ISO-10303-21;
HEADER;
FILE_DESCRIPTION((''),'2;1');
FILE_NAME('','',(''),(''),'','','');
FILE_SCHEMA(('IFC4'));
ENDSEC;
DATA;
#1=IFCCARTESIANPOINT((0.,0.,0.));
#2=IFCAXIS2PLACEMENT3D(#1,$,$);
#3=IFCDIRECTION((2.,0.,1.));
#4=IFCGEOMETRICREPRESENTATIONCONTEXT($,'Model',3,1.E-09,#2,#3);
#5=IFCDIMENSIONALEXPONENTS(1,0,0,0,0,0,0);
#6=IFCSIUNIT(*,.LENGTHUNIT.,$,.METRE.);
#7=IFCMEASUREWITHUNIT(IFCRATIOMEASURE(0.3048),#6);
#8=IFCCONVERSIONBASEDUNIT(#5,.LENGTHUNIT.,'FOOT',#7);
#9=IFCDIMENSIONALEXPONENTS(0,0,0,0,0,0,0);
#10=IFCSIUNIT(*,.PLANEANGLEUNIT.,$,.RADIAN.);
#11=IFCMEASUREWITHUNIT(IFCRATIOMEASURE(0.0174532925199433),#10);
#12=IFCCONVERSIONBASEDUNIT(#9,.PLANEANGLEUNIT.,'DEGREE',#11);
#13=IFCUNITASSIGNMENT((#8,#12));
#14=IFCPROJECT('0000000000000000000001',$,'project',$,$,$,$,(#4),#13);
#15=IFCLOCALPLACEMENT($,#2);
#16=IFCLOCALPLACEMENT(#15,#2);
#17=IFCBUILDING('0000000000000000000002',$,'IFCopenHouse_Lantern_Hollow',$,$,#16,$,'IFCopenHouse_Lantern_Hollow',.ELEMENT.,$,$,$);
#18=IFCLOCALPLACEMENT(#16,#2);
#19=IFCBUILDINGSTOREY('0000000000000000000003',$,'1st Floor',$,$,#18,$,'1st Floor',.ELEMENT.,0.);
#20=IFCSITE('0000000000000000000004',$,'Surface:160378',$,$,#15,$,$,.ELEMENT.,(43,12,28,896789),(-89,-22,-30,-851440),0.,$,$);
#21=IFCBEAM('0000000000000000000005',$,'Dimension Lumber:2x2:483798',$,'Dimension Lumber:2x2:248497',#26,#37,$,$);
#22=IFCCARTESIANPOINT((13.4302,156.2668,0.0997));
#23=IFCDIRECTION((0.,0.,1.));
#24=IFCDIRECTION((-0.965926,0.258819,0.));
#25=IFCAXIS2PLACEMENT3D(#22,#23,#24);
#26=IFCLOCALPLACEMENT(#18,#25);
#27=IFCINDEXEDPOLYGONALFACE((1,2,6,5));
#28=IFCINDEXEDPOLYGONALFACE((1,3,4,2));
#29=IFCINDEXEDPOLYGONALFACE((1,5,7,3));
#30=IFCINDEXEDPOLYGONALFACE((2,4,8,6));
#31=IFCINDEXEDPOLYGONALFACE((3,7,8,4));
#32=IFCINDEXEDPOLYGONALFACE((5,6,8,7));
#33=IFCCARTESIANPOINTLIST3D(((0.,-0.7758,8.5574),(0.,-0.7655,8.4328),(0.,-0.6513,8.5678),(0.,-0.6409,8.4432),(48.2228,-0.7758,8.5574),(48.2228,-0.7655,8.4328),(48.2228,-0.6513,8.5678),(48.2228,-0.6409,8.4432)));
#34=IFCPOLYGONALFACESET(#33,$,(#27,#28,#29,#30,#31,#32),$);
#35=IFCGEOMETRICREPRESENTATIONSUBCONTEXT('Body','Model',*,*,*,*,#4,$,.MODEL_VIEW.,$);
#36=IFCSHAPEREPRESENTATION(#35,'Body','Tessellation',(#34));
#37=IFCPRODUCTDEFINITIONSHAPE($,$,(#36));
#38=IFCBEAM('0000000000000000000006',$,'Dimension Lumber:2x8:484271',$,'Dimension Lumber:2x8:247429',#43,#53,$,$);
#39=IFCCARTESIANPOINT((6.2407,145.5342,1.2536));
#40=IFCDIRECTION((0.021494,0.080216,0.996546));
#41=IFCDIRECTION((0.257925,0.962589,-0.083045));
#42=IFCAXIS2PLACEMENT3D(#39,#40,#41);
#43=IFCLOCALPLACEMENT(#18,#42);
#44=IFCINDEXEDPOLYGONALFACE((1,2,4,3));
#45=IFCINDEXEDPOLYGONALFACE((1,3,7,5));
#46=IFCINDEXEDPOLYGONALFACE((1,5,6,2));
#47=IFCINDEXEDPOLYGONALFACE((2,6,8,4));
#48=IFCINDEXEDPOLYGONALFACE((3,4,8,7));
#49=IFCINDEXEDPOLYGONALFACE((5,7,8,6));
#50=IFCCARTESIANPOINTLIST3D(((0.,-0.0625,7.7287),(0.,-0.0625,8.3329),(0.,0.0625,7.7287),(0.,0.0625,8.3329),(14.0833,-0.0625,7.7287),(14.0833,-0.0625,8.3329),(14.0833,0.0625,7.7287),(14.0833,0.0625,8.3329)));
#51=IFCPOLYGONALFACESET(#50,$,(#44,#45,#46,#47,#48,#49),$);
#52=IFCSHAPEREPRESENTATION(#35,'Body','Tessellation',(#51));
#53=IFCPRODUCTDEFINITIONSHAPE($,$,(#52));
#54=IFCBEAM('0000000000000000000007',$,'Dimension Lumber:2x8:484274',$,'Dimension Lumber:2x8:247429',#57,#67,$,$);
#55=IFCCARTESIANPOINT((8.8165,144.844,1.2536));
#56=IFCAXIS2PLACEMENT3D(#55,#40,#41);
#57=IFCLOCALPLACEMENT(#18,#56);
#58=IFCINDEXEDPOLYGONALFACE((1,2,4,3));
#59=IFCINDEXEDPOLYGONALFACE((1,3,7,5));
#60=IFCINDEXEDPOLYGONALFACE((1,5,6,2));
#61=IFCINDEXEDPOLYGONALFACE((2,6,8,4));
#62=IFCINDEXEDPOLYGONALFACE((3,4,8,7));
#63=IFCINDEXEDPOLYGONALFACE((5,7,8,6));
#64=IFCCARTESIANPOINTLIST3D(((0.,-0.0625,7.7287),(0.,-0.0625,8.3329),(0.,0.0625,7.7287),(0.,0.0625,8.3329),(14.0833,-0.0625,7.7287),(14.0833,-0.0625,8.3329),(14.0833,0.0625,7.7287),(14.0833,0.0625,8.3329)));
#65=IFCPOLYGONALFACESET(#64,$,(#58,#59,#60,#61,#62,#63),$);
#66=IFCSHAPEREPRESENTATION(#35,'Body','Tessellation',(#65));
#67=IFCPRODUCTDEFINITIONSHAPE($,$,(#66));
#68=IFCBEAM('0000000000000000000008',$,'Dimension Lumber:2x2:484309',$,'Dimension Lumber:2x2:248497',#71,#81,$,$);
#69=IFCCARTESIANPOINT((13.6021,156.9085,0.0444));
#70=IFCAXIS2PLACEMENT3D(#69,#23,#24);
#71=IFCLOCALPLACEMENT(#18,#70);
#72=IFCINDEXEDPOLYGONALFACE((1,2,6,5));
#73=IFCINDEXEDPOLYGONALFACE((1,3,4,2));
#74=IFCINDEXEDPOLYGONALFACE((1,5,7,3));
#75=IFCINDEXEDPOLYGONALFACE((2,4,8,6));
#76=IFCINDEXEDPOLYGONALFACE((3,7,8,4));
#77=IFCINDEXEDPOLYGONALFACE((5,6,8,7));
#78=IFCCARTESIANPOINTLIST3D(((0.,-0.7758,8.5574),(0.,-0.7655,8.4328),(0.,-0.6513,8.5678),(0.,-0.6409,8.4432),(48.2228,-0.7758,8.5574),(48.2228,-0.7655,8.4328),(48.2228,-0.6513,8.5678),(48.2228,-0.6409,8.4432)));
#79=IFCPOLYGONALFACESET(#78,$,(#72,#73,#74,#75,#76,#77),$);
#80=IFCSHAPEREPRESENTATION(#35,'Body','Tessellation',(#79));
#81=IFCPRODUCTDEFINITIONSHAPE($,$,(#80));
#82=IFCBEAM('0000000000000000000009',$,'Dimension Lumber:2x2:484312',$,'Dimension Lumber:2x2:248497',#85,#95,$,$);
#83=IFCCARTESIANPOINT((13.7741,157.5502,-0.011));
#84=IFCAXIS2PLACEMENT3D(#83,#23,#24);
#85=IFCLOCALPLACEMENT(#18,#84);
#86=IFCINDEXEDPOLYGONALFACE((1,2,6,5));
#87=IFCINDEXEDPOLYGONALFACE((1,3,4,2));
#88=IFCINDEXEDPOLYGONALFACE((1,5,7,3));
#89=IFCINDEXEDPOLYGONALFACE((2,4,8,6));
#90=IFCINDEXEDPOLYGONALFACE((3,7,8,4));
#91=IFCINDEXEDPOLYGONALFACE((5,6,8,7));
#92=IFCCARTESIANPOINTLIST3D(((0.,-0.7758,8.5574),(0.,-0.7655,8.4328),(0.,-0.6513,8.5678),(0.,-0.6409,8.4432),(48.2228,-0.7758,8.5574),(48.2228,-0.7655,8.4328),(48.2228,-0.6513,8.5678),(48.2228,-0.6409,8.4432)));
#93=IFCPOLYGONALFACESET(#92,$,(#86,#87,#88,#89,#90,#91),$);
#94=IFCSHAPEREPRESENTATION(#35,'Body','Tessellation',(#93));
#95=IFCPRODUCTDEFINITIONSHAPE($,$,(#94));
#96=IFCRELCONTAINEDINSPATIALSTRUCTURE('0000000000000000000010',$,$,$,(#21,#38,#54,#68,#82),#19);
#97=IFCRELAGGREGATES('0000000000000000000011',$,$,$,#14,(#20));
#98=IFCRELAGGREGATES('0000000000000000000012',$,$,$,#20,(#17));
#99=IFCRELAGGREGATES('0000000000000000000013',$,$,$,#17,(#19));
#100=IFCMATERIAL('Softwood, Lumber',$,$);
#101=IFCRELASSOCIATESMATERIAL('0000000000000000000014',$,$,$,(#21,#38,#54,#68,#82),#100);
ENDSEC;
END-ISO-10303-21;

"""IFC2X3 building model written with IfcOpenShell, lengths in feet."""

from ifc_helpers import new_model, entity, si_unit, converted_unit, direction, frame, frame_2d, origin, place, context, subcontext, project, spatial, rectangle, extrude, material, element, save


model = new_model("IFC2X3")

# Units and contexts
model_context = context("Model", 3, precision=1e-09, world=origin(), true_north=direction((2.0, 0.0, 1.0)))
body_context = subcontext(model_context, "Body", "Model", "MODEL_VIEW")
ifc_project = project(units=[converted_unit("LENGTHUNIT", "FOOT", entity("IfcRatioMeasure", 0.3048), si_unit("LENGTHUNIT", "METRE"), dimensions=[1, 0, 0, 0, 0, 0, 0]), converted_unit("PLANEANGLEUNIT", "DEGREE", entity("IfcRatioMeasure", 0.0174532925199433), si_unit("PLANEANGLEUNIT", "RADIAN"), dimensions=[0, 0, 0, 0, 0, 0, 0])], contexts=[model_context])

# Site, building, storey
site_placement = place(None, origin())
site = spatial("IfcSite", under=ifc_project, at=site_placement, Name="Surface:160378", CompositionType="ELEMENT", RefLatitude=(43, 12, 28, 896789), RefLongitude=(-89, -22, -30, -851440), RefElevation=0.0)
building_placement = place(site_placement, origin())
building = spatial("IfcBuilding", under=site, at=building_placement, Name="IFCopenHouse_Lantern_Hollow", LongName="IFCopenHouse_Lantern_Hollow", CompositionType="ELEMENT")
storey_placement = place(building_placement, origin())
storey = spatial("IfcBuildingStorey", under=building, at=storey_placement, Name="1st Floor", LongName="1st Floor", CompositionType="ELEMENT", Elevation=0.0)

# Beams
ifc_material = material(Name="Softwood, Lumber")
beam_1_placement = place(storey_placement, frame((13.4302, 156.2668, 0.0997), z_axis=(0.0, 0.0, 1.0), x_axis=(-0.965926, 0.258819, 0.0)))
element("IfcBeam", 1, at=beam_1_placement, inside=storey, material=ifc_material, Name="Dimension Lumber:2x2:483798", ObjectType="Dimension Lumber:2x2:248497", context=body_context, shape_type="SweptSolid", body=[
    extrude(rectangle(XDim=0.125, YDim=0.125, at=frame_2d((0.0, 0.0), x_axis=(0.0, 1.0))), frame((0.0, -0.7084, 8.5003), z_axis=(1.0, 0.0, 0.0), x_axis=(0.0, -0.996546, -0.083045)), (0.0, 0.0, 1.0), 48.2228),
])
beam_2_placement = place(storey_placement, frame((6.2407, 145.5342, 1.2536), z_axis=(0.021494, 0.080216, 0.996546), x_axis=(0.257925, 0.962589, -0.083045)))
element("IfcBeam", 2, at=beam_2_placement, inside=storey, material=ifc_material, Name="Dimension Lumber:2x8:484271", ObjectType="Dimension Lumber:2x8:247429", context=body_context, shape_type="SweptSolid", body=[
    extrude(rectangle(XDim=0.6042, YDim=0.125, at=frame_2d((0.0, 0.0), x_axis=(1.0, 0.0))), frame((0.0, 0.0, 8.0308), z_axis=(1.0, 0.0, 0.0), x_axis=(0.0, 0.0, -1.0)), (0.0, 0.0, 1.0), 14.0833),
])
beam_3_placement = place(storey_placement, frame((8.8165, 144.844, 1.2536), z_axis=(0.021494, 0.080216, 0.996546), x_axis=(0.257925, 0.962589, -0.083045)))
element("IfcBeam", 3, at=beam_3_placement, inside=storey, material=ifc_material, Name="Dimension Lumber:2x8:484274", ObjectType="Dimension Lumber:2x8:247429", context=body_context, shape_type="SweptSolid", body=[
    extrude(rectangle(XDim=0.6042, YDim=0.125, at=frame_2d((0.0, 0.0), x_axis=(1.0, 0.0))), frame((0.0, 0.0, 8.0308), z_axis=(1.0, 0.0, 0.0), x_axis=(0.0, 0.0, -1.0)), (0.0, 0.0, 1.0), 14.0833),
])
beam_4_placement = place(storey_placement, frame((13.6021, 156.9085, 0.0444), z_axis=(0.0, 0.0, 1.0), x_axis=(-0.965926, 0.258819, 0.0)))
element("IfcBeam", 4, at=beam_4_placement, inside=storey, material=ifc_material, Name="Dimension Lumber:2x2:484309", ObjectType="Dimension Lumber:2x2:248497", context=body_context, shape_type="SweptSolid", body=[
    extrude(rectangle(XDim=0.125, YDim=0.125, at=frame_2d((0.0, 0.0), x_axis=(0.0, 1.0))), frame((0.0, -0.7084, 8.5003), z_axis=(1.0, 0.0, 0.0), x_axis=(0.0, -0.996546, -0.083045)), (0.0, 0.0, 1.0), 48.2228),
])
beam_5_placement = place(storey_placement, frame((13.7741, 157.5502, -0.011), z_axis=(0.0, 0.0, 1.0), x_axis=(-0.965926, 0.258819, 0.0)))
element("IfcBeam", 5, at=beam_5_placement, inside=storey, material=ifc_material, Name="Dimension Lumber:2x2:484312", ObjectType="Dimension Lumber:2x2:248497", context=body_context, shape_type="SweptSolid", body=[
    extrude(rectangle(XDim=0.125, YDim=0.125, at=frame_2d((0.0, 0.0), x_axis=(0.0, 1.0))), frame((0.0, -0.7084, 8.5003), z_axis=(1.0, 0.0, 0.0), x_axis=(0.0, -0.996546, -0.083045)), (0.0, 0.0, 1.0), 48.2228),
])

save(model, "model.ifc")
